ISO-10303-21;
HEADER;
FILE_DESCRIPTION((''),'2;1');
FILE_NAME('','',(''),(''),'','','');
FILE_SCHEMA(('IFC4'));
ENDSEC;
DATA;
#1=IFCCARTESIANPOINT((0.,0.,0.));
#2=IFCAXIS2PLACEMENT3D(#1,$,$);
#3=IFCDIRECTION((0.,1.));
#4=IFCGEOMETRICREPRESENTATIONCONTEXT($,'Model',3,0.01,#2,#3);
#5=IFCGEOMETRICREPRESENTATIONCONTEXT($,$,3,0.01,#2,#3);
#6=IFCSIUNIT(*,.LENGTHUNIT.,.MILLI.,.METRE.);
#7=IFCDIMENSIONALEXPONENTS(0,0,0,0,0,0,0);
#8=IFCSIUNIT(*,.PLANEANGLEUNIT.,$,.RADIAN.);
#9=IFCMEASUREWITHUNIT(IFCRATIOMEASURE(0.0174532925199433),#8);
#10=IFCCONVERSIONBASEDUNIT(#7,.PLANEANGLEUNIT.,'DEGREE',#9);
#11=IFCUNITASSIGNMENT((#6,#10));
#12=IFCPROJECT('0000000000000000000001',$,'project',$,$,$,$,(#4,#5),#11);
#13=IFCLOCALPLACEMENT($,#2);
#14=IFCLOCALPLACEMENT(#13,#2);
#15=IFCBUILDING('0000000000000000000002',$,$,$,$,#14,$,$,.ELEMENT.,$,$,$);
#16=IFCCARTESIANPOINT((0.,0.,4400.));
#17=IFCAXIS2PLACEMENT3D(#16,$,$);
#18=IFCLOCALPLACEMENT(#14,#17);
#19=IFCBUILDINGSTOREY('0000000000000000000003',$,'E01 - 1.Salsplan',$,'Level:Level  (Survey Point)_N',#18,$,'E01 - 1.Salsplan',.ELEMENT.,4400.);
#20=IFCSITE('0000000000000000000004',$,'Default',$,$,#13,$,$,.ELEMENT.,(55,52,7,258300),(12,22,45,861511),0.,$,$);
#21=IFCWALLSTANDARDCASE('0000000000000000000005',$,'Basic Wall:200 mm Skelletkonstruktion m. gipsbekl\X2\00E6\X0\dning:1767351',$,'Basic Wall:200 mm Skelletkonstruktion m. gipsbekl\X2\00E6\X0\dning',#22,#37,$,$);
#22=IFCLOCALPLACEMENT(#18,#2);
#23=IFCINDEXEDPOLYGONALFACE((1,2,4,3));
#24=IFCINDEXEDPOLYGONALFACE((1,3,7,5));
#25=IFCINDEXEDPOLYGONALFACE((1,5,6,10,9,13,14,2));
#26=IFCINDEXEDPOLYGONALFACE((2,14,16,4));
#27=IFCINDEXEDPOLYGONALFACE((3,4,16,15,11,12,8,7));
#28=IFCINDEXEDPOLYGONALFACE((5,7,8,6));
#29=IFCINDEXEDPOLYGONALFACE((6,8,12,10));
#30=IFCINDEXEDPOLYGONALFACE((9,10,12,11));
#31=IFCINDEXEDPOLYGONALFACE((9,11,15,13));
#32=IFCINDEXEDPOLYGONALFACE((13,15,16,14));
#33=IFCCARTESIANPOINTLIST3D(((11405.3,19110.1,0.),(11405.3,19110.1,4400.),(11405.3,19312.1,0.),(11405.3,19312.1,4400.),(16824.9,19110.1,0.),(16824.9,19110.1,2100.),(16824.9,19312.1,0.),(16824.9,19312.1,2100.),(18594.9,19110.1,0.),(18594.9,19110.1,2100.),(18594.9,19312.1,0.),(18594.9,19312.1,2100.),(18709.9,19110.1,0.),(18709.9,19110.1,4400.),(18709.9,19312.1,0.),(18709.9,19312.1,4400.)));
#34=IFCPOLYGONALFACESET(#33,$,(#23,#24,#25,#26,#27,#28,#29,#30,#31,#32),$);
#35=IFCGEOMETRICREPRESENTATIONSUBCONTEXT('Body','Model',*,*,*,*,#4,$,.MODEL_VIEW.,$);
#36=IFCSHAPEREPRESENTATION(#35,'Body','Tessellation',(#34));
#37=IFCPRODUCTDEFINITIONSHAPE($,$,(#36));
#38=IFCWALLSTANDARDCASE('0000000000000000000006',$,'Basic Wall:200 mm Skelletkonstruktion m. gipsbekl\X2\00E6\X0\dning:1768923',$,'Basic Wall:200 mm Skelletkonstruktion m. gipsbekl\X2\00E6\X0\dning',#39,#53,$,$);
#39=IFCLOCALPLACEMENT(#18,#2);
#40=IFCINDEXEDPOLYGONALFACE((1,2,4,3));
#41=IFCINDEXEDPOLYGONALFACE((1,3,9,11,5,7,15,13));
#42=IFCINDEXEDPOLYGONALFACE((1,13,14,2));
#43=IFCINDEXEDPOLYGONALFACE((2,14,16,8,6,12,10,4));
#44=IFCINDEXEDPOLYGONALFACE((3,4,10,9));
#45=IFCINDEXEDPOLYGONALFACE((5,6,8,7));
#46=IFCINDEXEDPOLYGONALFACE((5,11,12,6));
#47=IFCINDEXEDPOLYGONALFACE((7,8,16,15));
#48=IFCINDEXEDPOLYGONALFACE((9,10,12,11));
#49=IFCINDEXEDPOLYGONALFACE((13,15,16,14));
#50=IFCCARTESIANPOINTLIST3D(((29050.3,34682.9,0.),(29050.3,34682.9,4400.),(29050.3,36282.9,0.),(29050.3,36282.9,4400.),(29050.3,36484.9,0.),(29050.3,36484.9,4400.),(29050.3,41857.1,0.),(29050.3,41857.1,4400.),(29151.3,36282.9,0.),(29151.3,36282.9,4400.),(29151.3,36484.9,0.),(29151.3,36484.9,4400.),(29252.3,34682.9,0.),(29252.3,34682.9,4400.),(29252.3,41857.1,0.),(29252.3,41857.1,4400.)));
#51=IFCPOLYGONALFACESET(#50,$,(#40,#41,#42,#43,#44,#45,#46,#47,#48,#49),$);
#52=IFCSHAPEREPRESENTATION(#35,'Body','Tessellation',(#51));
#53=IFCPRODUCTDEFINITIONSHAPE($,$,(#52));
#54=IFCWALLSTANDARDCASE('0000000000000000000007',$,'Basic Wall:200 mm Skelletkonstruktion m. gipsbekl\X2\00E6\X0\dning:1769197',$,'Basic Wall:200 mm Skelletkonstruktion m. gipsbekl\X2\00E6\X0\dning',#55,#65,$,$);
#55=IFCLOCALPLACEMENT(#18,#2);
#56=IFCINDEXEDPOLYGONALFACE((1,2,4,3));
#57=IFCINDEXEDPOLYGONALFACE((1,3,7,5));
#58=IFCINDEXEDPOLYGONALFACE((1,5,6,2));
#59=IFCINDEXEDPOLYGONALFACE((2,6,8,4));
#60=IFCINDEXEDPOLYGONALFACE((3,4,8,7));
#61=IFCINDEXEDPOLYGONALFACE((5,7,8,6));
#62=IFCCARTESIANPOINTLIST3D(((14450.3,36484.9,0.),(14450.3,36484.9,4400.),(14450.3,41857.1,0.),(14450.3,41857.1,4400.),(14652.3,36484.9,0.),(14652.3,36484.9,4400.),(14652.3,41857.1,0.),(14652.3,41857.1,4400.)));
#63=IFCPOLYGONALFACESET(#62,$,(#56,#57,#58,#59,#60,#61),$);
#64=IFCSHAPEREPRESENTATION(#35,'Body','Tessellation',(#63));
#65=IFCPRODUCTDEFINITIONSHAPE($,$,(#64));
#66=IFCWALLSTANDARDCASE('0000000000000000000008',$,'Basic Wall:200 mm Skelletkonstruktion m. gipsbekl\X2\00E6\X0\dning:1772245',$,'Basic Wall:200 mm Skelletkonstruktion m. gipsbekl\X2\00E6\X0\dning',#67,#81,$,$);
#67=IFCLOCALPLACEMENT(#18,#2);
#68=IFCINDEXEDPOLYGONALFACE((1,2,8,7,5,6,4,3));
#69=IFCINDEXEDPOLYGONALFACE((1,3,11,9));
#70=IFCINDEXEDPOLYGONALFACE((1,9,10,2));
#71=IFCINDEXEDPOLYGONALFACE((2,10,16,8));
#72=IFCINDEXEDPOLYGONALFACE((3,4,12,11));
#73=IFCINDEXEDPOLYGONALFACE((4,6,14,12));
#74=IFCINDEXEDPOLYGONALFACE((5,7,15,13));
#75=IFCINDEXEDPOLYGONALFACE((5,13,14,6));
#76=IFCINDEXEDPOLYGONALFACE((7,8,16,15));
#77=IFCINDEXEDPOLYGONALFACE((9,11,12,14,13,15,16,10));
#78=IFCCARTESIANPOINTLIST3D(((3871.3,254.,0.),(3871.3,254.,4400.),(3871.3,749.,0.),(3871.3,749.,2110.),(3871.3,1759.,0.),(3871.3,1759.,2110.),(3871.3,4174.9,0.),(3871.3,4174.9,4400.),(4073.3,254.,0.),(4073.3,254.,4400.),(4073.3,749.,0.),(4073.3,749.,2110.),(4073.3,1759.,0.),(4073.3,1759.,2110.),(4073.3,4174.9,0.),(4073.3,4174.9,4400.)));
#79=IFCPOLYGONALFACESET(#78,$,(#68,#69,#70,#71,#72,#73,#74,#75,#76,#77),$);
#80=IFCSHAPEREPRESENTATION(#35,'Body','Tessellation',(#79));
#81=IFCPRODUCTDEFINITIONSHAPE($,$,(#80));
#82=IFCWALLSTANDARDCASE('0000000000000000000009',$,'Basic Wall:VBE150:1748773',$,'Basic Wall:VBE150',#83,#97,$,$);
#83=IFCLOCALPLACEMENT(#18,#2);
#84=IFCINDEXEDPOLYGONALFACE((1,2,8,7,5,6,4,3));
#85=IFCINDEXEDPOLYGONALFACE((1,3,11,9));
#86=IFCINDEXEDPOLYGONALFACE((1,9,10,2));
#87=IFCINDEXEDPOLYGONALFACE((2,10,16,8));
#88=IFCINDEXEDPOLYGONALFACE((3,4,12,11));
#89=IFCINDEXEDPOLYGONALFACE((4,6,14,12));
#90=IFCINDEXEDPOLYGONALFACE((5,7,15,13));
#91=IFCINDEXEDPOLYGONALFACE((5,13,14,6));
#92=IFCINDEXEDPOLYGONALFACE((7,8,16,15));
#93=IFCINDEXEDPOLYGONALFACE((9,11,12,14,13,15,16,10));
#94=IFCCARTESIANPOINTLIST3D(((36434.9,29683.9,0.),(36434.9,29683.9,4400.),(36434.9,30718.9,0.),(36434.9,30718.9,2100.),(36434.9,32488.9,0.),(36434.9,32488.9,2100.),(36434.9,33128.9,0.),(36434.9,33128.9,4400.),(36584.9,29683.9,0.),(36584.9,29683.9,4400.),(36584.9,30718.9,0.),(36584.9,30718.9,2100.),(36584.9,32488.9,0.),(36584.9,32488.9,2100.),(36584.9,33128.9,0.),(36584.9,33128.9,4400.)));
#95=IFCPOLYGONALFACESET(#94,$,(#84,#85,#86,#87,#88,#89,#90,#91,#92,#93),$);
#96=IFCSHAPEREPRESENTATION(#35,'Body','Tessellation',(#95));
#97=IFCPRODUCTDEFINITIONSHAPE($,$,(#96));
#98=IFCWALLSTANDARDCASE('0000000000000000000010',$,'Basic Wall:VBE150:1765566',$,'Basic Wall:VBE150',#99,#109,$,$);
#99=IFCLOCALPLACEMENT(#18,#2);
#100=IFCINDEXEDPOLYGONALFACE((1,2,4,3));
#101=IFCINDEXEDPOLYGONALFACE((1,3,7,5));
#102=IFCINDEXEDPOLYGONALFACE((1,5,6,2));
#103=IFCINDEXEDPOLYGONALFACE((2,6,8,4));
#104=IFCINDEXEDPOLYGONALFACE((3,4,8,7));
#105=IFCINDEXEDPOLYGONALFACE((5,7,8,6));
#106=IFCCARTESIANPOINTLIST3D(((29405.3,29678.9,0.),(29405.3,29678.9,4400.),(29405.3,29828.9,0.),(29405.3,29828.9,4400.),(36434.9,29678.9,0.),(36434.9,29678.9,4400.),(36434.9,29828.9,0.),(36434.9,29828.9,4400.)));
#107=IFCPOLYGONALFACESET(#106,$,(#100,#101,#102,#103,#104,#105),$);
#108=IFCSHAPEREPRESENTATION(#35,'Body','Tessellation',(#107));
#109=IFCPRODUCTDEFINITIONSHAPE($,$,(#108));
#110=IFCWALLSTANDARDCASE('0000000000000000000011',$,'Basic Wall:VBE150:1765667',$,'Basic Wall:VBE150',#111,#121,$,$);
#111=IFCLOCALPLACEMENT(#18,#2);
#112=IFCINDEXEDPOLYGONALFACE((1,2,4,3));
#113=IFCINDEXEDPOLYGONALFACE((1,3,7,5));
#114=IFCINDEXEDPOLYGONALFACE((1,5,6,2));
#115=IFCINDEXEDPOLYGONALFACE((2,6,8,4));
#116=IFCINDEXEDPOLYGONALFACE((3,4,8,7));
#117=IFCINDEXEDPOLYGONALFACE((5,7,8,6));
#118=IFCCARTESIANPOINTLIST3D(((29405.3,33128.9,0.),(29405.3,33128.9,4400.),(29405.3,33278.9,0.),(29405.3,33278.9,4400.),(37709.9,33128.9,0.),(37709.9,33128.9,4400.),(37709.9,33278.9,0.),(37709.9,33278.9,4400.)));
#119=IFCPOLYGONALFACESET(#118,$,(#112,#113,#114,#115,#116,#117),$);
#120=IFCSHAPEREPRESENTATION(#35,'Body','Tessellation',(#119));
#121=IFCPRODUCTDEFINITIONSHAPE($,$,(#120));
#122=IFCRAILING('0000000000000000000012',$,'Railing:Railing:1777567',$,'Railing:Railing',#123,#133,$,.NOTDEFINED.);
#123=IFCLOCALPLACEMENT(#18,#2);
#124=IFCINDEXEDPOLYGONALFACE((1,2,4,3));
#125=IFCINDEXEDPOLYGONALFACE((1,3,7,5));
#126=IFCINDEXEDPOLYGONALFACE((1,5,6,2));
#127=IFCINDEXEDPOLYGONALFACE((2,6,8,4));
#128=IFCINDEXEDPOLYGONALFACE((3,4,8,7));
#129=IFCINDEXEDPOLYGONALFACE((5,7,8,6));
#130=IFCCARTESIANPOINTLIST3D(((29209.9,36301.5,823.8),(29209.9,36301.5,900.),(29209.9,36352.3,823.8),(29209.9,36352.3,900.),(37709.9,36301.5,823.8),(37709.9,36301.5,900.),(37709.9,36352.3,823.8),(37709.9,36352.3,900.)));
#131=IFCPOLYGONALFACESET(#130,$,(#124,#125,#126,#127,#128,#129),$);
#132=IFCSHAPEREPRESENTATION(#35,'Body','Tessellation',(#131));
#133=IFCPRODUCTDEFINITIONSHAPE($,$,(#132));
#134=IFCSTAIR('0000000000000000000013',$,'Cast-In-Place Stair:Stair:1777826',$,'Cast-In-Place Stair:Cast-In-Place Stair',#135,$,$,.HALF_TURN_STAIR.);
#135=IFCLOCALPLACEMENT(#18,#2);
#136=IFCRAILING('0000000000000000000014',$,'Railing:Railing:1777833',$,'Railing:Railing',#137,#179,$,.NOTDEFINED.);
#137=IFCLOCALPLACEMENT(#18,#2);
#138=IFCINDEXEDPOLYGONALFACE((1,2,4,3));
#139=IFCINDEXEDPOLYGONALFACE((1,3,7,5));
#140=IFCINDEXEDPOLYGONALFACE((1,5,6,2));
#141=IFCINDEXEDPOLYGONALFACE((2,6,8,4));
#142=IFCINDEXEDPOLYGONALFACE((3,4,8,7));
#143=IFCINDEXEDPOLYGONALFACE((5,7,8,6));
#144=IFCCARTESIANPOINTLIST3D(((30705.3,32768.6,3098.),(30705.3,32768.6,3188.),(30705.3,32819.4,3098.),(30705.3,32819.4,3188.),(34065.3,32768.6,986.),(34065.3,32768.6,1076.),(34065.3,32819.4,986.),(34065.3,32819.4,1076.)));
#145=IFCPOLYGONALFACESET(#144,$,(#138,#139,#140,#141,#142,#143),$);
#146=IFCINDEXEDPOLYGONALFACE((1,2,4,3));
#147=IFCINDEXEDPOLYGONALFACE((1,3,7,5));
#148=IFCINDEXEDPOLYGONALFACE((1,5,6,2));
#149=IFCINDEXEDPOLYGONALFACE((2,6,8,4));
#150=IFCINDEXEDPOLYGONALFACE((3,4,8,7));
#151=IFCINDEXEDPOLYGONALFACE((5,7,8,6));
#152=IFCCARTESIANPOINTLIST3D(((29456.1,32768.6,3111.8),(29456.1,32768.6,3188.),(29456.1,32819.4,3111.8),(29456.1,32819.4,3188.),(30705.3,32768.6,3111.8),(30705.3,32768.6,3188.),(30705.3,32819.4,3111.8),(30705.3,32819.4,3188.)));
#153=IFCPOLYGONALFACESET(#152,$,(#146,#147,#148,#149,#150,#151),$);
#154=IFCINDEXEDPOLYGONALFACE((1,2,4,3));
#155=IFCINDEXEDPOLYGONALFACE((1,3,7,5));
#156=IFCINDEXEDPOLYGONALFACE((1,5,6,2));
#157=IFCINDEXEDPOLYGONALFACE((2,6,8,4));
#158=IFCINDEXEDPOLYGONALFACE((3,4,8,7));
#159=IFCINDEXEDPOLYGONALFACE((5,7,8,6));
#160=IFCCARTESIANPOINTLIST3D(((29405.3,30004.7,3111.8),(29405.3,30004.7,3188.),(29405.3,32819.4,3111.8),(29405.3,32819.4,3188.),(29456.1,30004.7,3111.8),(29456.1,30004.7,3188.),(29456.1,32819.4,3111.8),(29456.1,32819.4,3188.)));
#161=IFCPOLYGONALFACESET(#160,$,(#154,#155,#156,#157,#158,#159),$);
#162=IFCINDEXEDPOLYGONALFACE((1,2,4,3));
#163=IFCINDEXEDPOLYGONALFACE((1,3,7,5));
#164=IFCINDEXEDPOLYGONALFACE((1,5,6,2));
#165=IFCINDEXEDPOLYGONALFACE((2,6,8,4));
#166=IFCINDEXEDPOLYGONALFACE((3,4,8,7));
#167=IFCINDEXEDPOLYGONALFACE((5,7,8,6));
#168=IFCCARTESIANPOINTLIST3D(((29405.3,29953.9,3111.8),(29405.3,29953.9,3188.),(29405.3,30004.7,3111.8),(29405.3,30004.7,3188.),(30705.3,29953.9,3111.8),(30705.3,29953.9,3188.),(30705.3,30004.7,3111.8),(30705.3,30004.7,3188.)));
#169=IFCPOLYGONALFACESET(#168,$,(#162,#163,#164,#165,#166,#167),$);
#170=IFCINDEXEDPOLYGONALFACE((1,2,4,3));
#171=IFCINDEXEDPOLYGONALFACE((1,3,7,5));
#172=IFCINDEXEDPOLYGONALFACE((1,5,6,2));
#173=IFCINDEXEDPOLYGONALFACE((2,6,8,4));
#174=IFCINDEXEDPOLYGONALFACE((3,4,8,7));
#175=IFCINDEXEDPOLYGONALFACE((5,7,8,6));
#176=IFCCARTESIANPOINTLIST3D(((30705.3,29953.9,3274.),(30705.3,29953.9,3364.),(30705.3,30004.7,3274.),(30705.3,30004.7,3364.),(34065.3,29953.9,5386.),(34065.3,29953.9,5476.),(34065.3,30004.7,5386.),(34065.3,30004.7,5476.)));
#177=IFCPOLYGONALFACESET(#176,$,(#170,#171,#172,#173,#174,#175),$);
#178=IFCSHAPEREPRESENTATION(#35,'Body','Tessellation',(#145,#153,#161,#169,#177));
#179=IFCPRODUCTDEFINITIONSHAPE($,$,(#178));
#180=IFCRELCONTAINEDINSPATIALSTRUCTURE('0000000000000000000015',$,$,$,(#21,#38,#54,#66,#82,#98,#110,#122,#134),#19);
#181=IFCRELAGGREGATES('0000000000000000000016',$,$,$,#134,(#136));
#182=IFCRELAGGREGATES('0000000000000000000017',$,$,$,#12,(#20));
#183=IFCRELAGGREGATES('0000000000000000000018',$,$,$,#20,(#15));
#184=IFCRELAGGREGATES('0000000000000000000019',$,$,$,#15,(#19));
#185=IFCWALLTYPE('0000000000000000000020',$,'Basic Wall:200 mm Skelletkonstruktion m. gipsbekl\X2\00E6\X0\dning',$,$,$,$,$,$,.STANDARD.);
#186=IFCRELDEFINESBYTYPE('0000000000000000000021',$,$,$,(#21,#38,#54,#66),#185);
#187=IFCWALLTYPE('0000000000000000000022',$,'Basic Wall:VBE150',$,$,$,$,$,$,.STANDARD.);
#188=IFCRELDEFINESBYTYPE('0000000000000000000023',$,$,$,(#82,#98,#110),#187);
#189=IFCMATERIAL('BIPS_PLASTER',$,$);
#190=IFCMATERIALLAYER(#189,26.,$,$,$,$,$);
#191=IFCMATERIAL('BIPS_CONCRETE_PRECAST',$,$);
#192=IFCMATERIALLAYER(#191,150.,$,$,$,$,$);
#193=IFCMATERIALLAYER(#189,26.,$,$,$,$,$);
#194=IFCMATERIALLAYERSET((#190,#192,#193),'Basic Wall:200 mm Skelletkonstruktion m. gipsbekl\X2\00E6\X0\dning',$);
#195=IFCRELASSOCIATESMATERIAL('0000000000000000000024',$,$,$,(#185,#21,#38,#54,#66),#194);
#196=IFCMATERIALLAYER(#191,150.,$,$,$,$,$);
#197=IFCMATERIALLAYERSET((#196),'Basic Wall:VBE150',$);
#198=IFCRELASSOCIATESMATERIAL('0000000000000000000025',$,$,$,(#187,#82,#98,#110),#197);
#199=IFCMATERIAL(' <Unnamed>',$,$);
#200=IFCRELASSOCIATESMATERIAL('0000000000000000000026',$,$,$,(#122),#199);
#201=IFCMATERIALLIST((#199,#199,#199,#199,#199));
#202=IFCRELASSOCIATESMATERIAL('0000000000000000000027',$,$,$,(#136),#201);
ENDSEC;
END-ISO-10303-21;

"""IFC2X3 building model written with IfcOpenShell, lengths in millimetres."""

from ifc_helpers import new_model, entity, si_unit, converted_unit, direction, frame, frame_2d, origin, place, context, subcontext, project, spatial, polyline, rectangle, outline, extrude, clip, bounded_halfspace, material, material_list, layer, layer_set, layer_usage, type_object, element, aggregate, save


model = new_model("IFC2X3")

# Units and contexts
model_context = context("Model", 3, precision=0.01, world=origin(), true_north=direction((0.0, 1.0)))
context_of_model = context(None, 3, precision=0.01, world=origin(), true_north=direction((0.0, 1.0)))
body_context = subcontext(model_context, "Body", "Model", "MODEL_VIEW")
ifc_project = project(units=[si_unit("LENGTHUNIT", "METRE", prefix="MILLI"), converted_unit("PLANEANGLEUNIT", "DEGREE", entity("IfcRatioMeasure", 0.0174532925199433), si_unit("PLANEANGLEUNIT", "RADIAN"), dimensions=[0, 0, 0, 0, 0, 0, 0])], contexts=[model_context, context_of_model])

# Site, building, storey
site_placement = place(None, origin())
site = spatial("IfcSite", under=ifc_project, at=site_placement, Name="Default", CompositionType="ELEMENT", RefLatitude=(55, 52, 7, 258300), RefLongitude=(12, 22, 45, 861511), RefElevation=0.0)
building_placement = place(site_placement, origin())
building = spatial("IfcBuilding", under=site, at=building_placement, CompositionType="ELEMENT")
storey_placement = place(building_placement, frame((0.0, 0.0, 4400.0)))
storey = spatial("IfcBuildingStorey", under=building, at=storey_placement, Name="E01 - 1.Salsplan", ObjectType="Level:Level  (Survey Point)_N", LongName="E01 - 1.Salsplan", CompositionType="ELEMENT", Elevation=4400.0)

# Shared definitions
ifc_material_1 = material(Name="BIPS_CONCRETE_PRECAST")

# Shared definitions
ifc_material_2 = material(Name="BIPS_PLASTER")
ifc_layer_1 = layer(ifc_material_2, 26.0)
ifc_layer_2 = layer(ifc_material_1, 150.0)
ifc_layer_3 = layer(ifc_material_2, 26.0)
ifc_layer_set_1 = layer_set([ifc_layer_1, ifc_layer_2, ifc_layer_3], Name="Basic Wall:200 mm Skelletkonstruktion m. gipsbeklædning")
wall_type_1 = type_object("IfcWallType", Name="Basic Wall:200 mm Skelletkonstruktion m. gipsbeklædning", PredefinedType="STANDARD", material=ifc_layer_set_1)

# Wall, opening
ifc_layer_usage_1 = layer_usage(ifc_layer_set_1, "AXIS2", "NEGATIVE", 101.0)
wall_1_placement = place(storey_placement, frame((18709.9, 19211.1, 0.0), z_axis=(0.0, 0.0, 1.0), x_axis=(-1.0, 0.0, 0.0)))
wall_1 = element("IfcWallStandardCase", 1, at=wall_1_placement, inside=storey, type_object=wall_type_1, material=ifc_layer_usage_1, Name="Basic Wall:200 mm Skelletkonstruktion m. gipsbeklædning:1767351", ObjectType="Basic Wall:200 mm Skelletkonstruktion m. gipsbeklædning", context=body_context, shape_type="SweptSolid", body=[
    extrude(rectangle(XDim=7304.6, YDim=202.0, at=frame_2d((3652.3, 0.0), x_axis=(-1.0, 0.0))), origin(), (0.0, 0.0, 1.0), 4400.0),
])
opening_1_placement = place(wall_1_placement, frame((115.0, -101.0, 0.0)))
element("IfcOpeningElement", 2, at=opening_1_placement, cuts=wall_1, ObjectType="Opening", context=body_context, shape_type="SweptSolid", body=[
    extrude(rectangle(XDim=2100.0, YDim=1770.0, at=frame_2d((1050.0, 885.0), x_axis=(1.0, 0.0))), frame((0.0, 0.0, 0.0), z_axis=(0.0, 1.0, 0.0), x_axis=(0.0, 0.0, 1.0)), (0.0, 0.0, 1.0), 202.0),
])

# Walls
ifc_layer_usage_2 = layer_usage(ifc_layer_set_1, "AXIS2", "NEGATIVE", 101.0)
wall_2_placement = place(storey_placement, frame((29151.3, 34682.9, 0.0), z_axis=(0.0, 0.0, 1.0), x_axis=(0.0, 1.0, 0.0)))
element("IfcWallStandardCase", 3, at=wall_2_placement, inside=storey, type_object=wall_type_1, material=ifc_layer_usage_2, Name="Basic Wall:200 mm Skelletkonstruktion m. gipsbeklædning:1768923", ObjectType="Basic Wall:200 mm Skelletkonstruktion m. gipsbeklædning", context=body_context, shape_type="Clipping", body=[
    clip(extrude(rectangle(XDim=7174.3, YDim=202.0, at=frame_2d((3587.1, 0.0), x_axis=(-1.0, 0.0))), origin(), (0.0, 0.0, 1.0), 4400.0), bounded_halfspace(frame((1802.0, 0.0, 4400.0), z_axis=(0.0, -1.0, 0.0), x_axis=(-1.0, 0.0, 0.0)), True, frame((1802.0, 0.0, 4400.0), z_axis=(0.0, -1.0, 0.0), x_axis=(-1.0, 0.0, 0.0)), polyline([(0.0, 0.0), (202.0, 0.0), (202.0, 4400.0), (0.0, 4400.0), (0.0, 0.0)]))),
])
ifc_layer_usage_3 = layer_usage(ifc_layer_set_1, "AXIS2", "NEGATIVE", 101.0)
wall_3_placement = place(storey_placement, frame((14551.3, 36484.9, 0.0), z_axis=(0.0, 0.0, 1.0), x_axis=(0.0, 1.0, 0.0)))
element("IfcWallStandardCase", 4, at=wall_3_placement, inside=storey, type_object=wall_type_1, material=ifc_layer_usage_3, Name="Basic Wall:200 mm Skelletkonstruktion m. gipsbeklædning:1769197", ObjectType="Basic Wall:200 mm Skelletkonstruktion m. gipsbeklædning", context=body_context, shape_type="SweptSolid", body=[
    extrude(rectangle(XDim=5372.3, YDim=202.0, at=frame_2d((2686.1, 0.0), x_axis=(-1.0, 0.0))), origin(), (0.0, 0.0, 1.0), 4400.0),
])

# Walls, openings
ifc_layer_usage_4 = layer_usage(ifc_layer_set_1, "AXIS2", "NEGATIVE", 101.0)
wall_4_placement = place(storey_placement, frame((3972.3, 254.0, 0.0), z_axis=(0.0, 0.0, 1.0), x_axis=(0.0, 1.0, 0.0)))
wall_4 = element("IfcWallStandardCase", 5, at=wall_4_placement, inside=storey, type_object=wall_type_1, material=ifc_layer_usage_4, Name="Basic Wall:200 mm Skelletkonstruktion m. gipsbeklædning:1772245", ObjectType="Basic Wall:200 mm Skelletkonstruktion m. gipsbeklædning", context=body_context, shape_type="SweptSolid", body=[
    extrude(rectangle(XDim=3920.9, YDim=202.0, at=frame_2d((1960.4, 0.0), x_axis=(-1.0, 0.0))), origin(), (0.0, 0.0, 1.0), 4400.0),
])
opening_2_placement = place(wall_4_placement, frame((1505.0, 101.0, 0.0)))
element("IfcOpeningElement", 6, at=opening_2_placement, cuts=wall_4, ObjectType="Opening", context=body_context, shape_type="SweptSolid", body=[
    extrude(rectangle(XDim=2110.0, YDim=1010.0, at=frame_2d((1055.0, 505.0), x_axis=(1.0, 0.0))), frame((0.0, 0.0, 0.0), z_axis=(0.0, -1.0, 0.0), x_axis=(0.0, 0.0, 1.0)), (0.0, 0.0, 1.0), 202.0),
])
ifc_layer_4 = layer(ifc_material_1, 150.0)
ifc_layer_set_2 = layer_set([ifc_layer_4], Name="Basic Wall:VBE150")
ifc_layer_usage_5 = layer_usage(ifc_layer_set_2, "AXIS2", "NEGATIVE", 75.0)
wall_type_2 = type_object("IfcWallType", Name="Basic Wall:VBE150", PredefinedType="STANDARD", material=ifc_layer_set_2)
wall_5_placement = place(storey_placement, frame((36509.9, 29683.9, 0.0), z_axis=(0.0, 0.0, 1.0), x_axis=(0.0, 1.0, 0.0)))
wall_5 = element("IfcWallStandardCase", 7, at=wall_5_placement, inside=storey, type_object=wall_type_2, material=ifc_layer_usage_5, Name="Basic Wall:VBE150:1748773", ObjectType="Basic Wall:VBE150", context=body_context, shape_type="SweptSolid", body=[
    extrude(rectangle(XDim=3445.0, YDim=150.0, at=frame_2d((1722.5, 0.0), x_axis=(-1.0, 0.0))), origin(), (0.0, 0.0, 1.0), 4400.0),
])
opening_3_placement = place(wall_5_placement, frame((1035.0, -75.0, 0.0)))
element("IfcOpeningElement", 8, at=opening_3_placement, cuts=wall_5, ObjectType="Opening", context=body_context, shape_type="SweptSolid", body=[
    extrude(rectangle(XDim=2100.0, YDim=1770.0, at=frame_2d((1050.0, 885.0), x_axis=(1.0, 0.0))), frame((0.0, 0.0, 0.0), z_axis=(0.0, 1.0, 0.0), x_axis=(0.0, 0.0, 1.0)), (0.0, 0.0, 1.0), 150.0),
])

# Walls
ifc_layer_usage_6 = layer_usage(ifc_layer_set_2, "AXIS2", "NEGATIVE", 75.0)
wall_6_placement = place(storey_placement, frame((29405.3, 29753.9, 0.0)))
element("IfcWallStandardCase", 9, at=wall_6_placement, inside=storey, type_object=wall_type_2, material=ifc_layer_usage_6, Name="Basic Wall:VBE150:1765566", ObjectType="Basic Wall:VBE150", context=body_context, shape_type="SweptSolid", body=[
    extrude(rectangle(XDim=7029.6, YDim=150.0, at=frame_2d((3514.8, 0.0), x_axis=(-1.0, 0.0))), origin(), (0.0, 0.0, 1.0), 4400.0),
])
ifc_layer_usage_7 = layer_usage(ifc_layer_set_2, "AXIS2", "NEGATIVE", 75.0)
wall_7_placement = place(storey_placement, frame((29405.3, 33203.9, 0.0)))
element("IfcWallStandardCase", 10, at=wall_7_placement, inside=storey, type_object=wall_type_2, material=ifc_layer_usage_7, Name="Basic Wall:VBE150:1765667", ObjectType="Basic Wall:VBE150", context=body_context, shape_type="SweptSolid", body=[
    extrude(rectangle(XDim=8304.6, YDim=150.0, at=frame_2d((4152.3, 0.0), x_axis=(-1.0, 0.0))), origin(), (0.0, 0.0, 1.0), 4400.0),
])

# Railing
ifc_material_3 = material(Name=" <Unnamed>")
railing_1_placement = place(storey_placement, origin())
element("IfcRailing", 11, at=railing_1_placement, inside=storey, material=ifc_material_3, Name="Railing:Railing:1777567", ObjectType="Railing:Railing", PredefinedType="NOTDEFINED", context=body_context, shape_type="SweptSolid", body=[
    extrude(rectangle(XDim=8500.0, YDim=50.8, at=frame_2d((0.0, 0.0), x_axis=(1.0, 0.0))), frame((33459.9, 36326.9, 823.8), z_axis=(0.0, 0.0, 1.0), x_axis=(-1.0, 0.0, 0.0)), (0.0, 0.0, 1.0), 76.2),
])

# Stair, railing
stair_placement = place(storey_placement, origin())
stair = element("IfcStair", 12, at=stair_placement, inside=storey, Name="Cast-In-Place Stair:Stair:1777826", ObjectType="Cast-In-Place Stair:Cast-In-Place Stair", ShapeType="HALF_TURN_STAIR")
ifc_material_list = material_list([ifc_material_3, ifc_material_3, ifc_material_3, ifc_material_3, ifc_material_3])
railing_2_placement = place(stair_placement, origin())
railing_2 = element("IfcRailing", 13, at=railing_2_placement, material=ifc_material_list, Name="Railing:Railing:1777833", ObjectType="Railing:Railing", PredefinedType="NOTDEFINED", context=body_context, shape_type="SweptSolid", body=[
    extrude(outline(polyline([(-2008.3, -38.1), (1960.4, -38.1), (2008.3, 38.1), (-1960.4, 38.1), (-2008.3, -38.1)])), frame((32385.3, 32768.6, 2087.0), z_axis=(0.0, 1.0, 0.0), x_axis=(-0.846637, 0.0, 0.532172)), (0.0, 0.0, 1.0), 50.8),
    extrude(rectangle(XDim=1249.2, YDim=50.8, at=frame_2d((0.0, 0.0), x_axis=(1.0, 0.0))), frame((30080.7, 32794.0, 3111.8), z_axis=(0.0, 0.0, 1.0), x_axis=(-1.0, 0.0, 0.0)), (0.0, 0.0, 1.0), 76.2),
    extrude(rectangle(XDim=2814.7, YDim=50.8, at=frame_2d((0.0, 0.0), x_axis=(1.0, 0.0))), frame((29430.7, 31412.0, 3111.8), z_axis=(0.0, 0.0, 1.0), x_axis=(0.0, -1.0, 0.0)), (0.0, 0.0, 1.0), 76.2),
    extrude(rectangle(XDim=1300.0, YDim=50.8, at=frame_2d((0.0, 0.0), x_axis=(1.0, 0.0))), frame((30055.3, 29979.3, 3111.8)), (0.0, 0.0, 1.0), 76.2),
    extrude(outline(polyline([(-1960.4, -38.1), (2008.3, -38.1), (1960.4, 38.1), (-2008.3, 38.1), (-1960.4, -38.1)])), frame((32385.3, 29953.9, 4375.0), z_axis=(0.0, 1.0, 0.0), x_axis=(0.846637, 0.0, 0.532172)), (0.0, 0.0, 1.0), 50.8),
])
aggregate(stair, [railing_2])

save(model, "model.ifc")
